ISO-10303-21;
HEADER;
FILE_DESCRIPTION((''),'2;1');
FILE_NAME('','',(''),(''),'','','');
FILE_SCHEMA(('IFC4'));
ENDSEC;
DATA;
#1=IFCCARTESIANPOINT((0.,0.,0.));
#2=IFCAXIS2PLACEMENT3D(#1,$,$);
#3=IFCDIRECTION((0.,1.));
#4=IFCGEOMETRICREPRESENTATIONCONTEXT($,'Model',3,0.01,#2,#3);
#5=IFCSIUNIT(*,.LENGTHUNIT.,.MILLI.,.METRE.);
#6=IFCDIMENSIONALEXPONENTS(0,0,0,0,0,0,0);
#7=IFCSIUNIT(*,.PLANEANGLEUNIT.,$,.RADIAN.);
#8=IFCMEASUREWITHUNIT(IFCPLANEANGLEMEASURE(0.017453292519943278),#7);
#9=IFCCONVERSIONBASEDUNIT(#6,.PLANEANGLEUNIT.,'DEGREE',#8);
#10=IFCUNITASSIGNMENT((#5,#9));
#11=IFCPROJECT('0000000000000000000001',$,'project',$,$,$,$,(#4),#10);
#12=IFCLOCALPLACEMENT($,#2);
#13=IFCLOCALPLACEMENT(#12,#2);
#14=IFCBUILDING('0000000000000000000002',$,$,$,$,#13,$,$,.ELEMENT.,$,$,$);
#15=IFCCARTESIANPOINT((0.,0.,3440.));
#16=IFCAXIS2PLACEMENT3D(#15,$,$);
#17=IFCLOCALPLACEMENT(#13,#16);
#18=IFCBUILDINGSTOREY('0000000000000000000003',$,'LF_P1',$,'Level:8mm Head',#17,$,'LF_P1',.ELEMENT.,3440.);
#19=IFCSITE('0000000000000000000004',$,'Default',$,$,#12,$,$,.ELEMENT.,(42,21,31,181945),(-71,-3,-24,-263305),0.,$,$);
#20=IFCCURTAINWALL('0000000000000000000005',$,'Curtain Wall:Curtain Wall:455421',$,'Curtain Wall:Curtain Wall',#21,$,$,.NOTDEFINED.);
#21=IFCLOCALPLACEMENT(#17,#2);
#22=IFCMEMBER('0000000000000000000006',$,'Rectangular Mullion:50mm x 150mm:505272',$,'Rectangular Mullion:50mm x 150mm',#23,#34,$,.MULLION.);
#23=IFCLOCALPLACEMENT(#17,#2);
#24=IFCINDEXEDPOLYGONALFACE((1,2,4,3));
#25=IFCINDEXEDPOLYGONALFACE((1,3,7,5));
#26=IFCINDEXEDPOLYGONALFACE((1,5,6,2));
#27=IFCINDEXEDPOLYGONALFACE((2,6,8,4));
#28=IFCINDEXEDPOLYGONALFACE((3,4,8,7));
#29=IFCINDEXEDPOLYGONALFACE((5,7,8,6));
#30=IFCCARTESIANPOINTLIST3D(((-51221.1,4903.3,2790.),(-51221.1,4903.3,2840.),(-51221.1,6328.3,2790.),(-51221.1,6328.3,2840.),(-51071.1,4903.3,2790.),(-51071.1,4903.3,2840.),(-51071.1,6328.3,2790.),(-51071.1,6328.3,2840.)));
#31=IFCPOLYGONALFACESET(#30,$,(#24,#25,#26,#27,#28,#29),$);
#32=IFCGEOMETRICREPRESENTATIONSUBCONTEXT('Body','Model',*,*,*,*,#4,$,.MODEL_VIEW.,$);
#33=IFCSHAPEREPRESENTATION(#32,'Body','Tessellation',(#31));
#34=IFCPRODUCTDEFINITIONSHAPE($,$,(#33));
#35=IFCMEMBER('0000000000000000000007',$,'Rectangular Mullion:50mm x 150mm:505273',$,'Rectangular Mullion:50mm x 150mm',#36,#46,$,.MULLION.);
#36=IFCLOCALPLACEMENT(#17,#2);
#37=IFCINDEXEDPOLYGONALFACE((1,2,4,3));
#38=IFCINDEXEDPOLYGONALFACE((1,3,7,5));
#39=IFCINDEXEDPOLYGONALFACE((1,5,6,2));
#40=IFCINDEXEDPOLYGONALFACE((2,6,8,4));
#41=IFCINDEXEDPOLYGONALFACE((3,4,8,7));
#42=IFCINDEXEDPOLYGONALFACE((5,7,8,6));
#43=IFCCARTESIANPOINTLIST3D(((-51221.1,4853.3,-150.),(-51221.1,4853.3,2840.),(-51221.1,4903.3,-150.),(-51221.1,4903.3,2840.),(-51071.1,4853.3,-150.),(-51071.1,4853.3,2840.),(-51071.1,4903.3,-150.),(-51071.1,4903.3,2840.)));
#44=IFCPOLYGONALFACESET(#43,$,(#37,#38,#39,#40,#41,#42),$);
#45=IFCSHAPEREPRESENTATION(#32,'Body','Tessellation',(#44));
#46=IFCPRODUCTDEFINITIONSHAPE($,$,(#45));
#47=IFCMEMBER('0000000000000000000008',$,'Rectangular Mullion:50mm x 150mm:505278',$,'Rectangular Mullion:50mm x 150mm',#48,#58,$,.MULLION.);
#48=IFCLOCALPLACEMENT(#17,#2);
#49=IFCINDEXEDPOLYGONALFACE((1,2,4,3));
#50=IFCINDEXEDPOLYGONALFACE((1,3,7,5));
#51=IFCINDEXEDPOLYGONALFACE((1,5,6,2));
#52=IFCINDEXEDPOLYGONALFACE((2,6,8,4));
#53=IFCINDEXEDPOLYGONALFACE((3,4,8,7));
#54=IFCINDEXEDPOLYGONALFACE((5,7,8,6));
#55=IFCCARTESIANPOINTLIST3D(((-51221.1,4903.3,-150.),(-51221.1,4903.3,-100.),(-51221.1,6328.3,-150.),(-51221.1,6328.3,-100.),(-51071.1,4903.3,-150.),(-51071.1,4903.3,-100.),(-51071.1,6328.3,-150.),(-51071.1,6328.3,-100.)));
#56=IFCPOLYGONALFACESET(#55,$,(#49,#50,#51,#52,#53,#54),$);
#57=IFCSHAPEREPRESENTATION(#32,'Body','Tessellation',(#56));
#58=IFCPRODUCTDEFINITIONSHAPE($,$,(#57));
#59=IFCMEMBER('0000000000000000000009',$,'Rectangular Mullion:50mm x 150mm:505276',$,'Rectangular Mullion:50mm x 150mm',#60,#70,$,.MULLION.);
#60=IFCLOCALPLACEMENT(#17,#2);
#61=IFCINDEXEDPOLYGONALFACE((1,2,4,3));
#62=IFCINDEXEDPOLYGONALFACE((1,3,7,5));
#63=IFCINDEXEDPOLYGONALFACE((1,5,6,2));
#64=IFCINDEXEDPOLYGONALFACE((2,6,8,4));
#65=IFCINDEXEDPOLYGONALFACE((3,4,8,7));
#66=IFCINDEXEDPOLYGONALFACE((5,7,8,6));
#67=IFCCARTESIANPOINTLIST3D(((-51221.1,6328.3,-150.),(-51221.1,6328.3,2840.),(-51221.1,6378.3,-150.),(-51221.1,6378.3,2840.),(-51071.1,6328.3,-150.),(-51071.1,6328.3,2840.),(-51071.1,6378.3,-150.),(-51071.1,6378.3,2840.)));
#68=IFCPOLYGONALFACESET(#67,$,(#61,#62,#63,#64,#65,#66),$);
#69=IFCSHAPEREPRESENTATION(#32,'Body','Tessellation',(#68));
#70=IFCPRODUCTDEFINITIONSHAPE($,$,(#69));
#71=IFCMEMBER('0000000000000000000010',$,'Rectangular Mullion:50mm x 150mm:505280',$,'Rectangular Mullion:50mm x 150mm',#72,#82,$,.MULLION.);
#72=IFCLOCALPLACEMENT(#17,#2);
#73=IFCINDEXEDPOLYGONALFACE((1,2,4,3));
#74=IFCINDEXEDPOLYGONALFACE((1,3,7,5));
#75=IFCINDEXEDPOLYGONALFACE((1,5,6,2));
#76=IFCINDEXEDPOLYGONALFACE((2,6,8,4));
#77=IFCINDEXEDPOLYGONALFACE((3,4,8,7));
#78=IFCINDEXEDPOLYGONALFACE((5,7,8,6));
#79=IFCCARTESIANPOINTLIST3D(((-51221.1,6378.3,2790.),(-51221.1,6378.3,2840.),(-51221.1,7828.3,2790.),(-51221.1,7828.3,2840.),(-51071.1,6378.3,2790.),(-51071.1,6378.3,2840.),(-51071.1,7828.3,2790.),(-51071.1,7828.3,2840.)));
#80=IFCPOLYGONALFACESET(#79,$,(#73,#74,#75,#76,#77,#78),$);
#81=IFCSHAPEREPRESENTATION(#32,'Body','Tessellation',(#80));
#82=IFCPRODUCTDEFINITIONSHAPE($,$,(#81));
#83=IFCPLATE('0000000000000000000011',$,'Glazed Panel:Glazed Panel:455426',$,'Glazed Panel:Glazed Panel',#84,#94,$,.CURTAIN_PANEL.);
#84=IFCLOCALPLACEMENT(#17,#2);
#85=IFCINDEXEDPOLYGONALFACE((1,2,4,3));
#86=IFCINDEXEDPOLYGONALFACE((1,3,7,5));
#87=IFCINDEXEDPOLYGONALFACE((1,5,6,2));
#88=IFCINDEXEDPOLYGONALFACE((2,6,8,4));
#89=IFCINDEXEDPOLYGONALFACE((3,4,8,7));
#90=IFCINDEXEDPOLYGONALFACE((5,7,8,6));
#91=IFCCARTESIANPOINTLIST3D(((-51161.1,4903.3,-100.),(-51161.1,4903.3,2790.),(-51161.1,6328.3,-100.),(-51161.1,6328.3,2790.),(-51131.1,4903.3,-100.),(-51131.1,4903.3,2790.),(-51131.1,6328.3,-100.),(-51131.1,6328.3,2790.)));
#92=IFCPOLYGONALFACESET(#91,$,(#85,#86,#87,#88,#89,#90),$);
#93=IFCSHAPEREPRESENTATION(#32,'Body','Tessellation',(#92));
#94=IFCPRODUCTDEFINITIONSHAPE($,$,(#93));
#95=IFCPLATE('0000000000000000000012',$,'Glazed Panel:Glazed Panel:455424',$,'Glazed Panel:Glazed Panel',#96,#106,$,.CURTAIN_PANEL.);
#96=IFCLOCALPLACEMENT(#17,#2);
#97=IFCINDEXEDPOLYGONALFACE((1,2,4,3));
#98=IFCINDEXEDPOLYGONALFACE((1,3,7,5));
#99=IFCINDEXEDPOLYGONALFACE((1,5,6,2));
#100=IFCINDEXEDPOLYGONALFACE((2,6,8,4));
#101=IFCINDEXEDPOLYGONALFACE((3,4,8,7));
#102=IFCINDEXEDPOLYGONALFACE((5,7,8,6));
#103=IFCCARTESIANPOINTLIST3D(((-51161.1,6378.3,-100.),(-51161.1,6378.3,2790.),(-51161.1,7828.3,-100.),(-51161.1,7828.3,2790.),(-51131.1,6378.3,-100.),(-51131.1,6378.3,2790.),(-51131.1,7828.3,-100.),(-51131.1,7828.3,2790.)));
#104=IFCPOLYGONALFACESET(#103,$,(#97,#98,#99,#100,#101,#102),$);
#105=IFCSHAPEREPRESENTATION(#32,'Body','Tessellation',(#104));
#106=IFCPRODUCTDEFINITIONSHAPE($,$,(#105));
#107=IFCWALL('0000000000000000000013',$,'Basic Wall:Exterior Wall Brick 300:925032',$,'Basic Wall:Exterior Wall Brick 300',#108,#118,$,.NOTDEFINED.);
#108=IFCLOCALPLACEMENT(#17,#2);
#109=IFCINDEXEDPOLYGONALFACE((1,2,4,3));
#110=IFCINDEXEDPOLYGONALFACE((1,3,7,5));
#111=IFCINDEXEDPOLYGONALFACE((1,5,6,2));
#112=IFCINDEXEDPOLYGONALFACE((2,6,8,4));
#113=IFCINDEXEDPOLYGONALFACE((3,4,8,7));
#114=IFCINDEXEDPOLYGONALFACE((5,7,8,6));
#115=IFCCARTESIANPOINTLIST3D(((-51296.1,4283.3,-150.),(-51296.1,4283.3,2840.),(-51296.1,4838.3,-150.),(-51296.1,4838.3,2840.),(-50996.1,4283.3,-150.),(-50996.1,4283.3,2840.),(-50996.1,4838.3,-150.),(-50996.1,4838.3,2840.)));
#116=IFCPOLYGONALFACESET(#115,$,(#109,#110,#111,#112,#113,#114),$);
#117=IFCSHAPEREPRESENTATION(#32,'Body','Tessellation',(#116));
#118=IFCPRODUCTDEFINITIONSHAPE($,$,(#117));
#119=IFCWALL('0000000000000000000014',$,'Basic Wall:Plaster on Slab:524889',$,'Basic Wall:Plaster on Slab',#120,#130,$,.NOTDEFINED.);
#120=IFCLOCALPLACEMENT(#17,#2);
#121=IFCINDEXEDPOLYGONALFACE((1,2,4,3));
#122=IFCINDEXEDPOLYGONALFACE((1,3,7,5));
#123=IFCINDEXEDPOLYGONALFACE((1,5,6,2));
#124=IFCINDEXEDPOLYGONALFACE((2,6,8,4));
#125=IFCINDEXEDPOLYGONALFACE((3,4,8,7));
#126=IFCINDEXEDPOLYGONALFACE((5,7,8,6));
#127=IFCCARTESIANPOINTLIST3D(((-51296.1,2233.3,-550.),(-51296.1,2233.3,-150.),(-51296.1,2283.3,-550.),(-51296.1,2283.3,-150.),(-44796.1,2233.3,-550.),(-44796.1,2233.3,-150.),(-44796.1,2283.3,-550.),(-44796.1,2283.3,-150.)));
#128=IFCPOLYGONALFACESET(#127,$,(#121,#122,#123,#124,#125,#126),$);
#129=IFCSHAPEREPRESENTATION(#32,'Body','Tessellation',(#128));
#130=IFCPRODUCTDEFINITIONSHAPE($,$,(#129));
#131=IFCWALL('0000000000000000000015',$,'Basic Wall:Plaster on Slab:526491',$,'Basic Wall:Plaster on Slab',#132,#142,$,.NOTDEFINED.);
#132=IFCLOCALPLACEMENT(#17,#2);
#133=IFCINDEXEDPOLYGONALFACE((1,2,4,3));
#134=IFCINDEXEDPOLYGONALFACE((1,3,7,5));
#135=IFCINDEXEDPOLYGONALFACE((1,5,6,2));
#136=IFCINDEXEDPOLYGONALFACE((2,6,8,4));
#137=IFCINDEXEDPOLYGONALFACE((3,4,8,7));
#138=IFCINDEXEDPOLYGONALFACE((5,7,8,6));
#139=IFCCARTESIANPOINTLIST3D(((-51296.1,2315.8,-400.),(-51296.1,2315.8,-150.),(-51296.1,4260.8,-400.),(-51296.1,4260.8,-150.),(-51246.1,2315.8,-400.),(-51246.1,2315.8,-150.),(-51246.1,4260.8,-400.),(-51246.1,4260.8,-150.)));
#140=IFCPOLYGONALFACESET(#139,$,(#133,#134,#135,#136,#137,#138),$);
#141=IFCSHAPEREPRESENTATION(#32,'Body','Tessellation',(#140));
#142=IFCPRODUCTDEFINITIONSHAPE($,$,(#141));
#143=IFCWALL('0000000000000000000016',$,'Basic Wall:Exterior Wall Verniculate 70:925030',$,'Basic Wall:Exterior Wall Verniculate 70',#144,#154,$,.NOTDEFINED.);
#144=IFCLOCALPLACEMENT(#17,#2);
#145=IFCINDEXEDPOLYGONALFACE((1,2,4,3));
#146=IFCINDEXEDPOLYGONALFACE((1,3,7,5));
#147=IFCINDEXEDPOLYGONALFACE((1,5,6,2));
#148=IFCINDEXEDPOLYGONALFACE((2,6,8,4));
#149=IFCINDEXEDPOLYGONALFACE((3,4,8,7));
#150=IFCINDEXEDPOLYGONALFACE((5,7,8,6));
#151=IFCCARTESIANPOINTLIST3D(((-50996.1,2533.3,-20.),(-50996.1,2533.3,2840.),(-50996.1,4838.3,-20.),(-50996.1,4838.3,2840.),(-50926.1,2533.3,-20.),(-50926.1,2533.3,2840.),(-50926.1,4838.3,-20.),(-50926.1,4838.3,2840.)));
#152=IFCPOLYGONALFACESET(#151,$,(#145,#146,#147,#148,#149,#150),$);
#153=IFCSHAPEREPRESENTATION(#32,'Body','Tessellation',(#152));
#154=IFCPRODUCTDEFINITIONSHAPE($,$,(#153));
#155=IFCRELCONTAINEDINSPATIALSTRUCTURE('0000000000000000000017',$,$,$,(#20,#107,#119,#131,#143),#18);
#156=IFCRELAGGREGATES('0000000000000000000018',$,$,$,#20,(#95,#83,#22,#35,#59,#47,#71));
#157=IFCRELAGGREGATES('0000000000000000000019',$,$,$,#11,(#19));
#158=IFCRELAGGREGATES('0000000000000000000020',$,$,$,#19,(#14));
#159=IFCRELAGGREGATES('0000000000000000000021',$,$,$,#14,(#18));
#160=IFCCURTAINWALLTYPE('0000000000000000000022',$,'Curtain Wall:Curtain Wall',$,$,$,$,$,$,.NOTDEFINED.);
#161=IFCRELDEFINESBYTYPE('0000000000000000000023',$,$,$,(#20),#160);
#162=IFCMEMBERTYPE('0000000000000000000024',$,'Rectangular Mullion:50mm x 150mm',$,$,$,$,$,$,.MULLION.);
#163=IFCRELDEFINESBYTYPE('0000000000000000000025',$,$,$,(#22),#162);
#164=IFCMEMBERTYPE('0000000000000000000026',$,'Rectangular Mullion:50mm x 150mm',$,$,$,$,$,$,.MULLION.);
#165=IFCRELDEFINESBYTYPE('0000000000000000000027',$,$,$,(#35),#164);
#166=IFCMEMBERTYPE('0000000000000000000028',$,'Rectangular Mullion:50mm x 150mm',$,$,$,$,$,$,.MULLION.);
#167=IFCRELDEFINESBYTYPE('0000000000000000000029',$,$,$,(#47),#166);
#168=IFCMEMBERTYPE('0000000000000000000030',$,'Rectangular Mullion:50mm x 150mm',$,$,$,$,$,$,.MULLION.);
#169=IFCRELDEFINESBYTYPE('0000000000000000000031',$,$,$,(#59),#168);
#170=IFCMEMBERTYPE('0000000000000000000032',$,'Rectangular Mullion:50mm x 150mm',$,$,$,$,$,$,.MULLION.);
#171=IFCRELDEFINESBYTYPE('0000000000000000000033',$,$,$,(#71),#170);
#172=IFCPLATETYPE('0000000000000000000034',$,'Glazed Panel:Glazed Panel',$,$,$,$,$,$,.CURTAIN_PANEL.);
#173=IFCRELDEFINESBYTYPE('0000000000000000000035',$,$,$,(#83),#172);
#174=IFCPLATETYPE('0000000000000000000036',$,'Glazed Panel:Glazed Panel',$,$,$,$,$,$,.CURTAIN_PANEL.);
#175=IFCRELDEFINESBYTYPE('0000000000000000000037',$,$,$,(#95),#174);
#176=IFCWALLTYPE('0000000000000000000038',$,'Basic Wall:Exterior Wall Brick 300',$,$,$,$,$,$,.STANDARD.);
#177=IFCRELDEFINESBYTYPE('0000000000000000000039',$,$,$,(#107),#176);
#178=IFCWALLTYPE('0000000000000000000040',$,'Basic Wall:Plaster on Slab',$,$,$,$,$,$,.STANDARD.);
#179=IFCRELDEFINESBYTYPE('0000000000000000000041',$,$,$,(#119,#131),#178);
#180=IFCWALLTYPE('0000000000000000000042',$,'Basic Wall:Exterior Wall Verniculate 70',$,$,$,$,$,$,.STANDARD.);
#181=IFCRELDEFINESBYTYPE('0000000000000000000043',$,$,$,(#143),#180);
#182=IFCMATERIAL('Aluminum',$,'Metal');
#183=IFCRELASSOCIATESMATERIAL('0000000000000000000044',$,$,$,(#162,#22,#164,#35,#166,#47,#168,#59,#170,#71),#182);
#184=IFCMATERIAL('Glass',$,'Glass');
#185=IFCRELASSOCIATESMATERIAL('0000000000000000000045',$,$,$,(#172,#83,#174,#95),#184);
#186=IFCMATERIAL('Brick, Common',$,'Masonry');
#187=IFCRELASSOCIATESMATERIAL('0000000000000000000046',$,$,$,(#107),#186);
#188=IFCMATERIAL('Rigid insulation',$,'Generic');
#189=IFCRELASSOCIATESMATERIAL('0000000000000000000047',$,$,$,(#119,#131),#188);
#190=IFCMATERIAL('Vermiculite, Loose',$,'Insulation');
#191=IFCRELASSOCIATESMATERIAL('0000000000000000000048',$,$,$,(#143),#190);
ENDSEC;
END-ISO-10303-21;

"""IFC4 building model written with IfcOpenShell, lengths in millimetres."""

from ifc_helpers import new_model, entity, si_unit, converted_unit, direction, frame, origin, place, context, subcontext, project, spatial, indexed_curve, outline, extrude, source, transform, mapped, material, type_object, type_shapes, element, aggregate, save


model = new_model("IFC4")

# Units and contexts
model_context = context("Model", 3, precision=0.01, world=origin(), true_north=direction((0.0, 1.0)))
body_context = subcontext(model_context, "Body", "Model", "MODEL_VIEW")
ifc_project = project(units=[si_unit("LENGTHUNIT", "METRE", prefix="MILLI"), converted_unit("PLANEANGLEUNIT", "DEGREE", entity("IfcPlaneAngleMeasure", 0.017453292519943278), si_unit("PLANEANGLEUNIT", "RADIAN"), dimensions=[0, 0, 0, 0, 0, 0, 0])], contexts=[model_context])

# Site, building, storey
site_placement = place(None, origin())
site = spatial("IfcSite", under=ifc_project, at=site_placement, Name="Default", CompositionType="ELEMENT", RefLatitude=(42, 21, 31, 181945), RefLongitude=(-71, -3, -24, -263305), RefElevation=0.0)
building_placement = place(site_placement, origin())
building = spatial("IfcBuilding", under=site, at=building_placement, CompositionType="ELEMENT")
storey_placement = place(building_placement, frame((0.0, 0.0, 3440.0)))
storey = spatial("IfcBuildingStorey", under=building, at=storey_placement, Name="LF_P1", ObjectType="Level:8mm Head", LongName="LF_P1", CompositionType="ELEMENT", Elevation=3440.0)

# Curtain wall, members, plates
curtain_wall_type = type_object("IfcCurtainWallType", Name="Curtain Wall:Curtain Wall", PredefinedType="NOTDEFINED")
curtain_wall_placement = place(storey_placement, frame((0.0, 0.0, -3440.0)))
curtain_wall = element("IfcCurtainWall", 1, at=curtain_wall_placement, inside=storey, type_object=curtain_wall_type, Name="Curtain Wall:Curtain Wall:455421", ObjectType="Curtain Wall:Curtain Wall", PredefinedType="NOTDEFINED")
ifc_material_1 = material(Name="Aluminum", Category="Metal")
member_type_1 = type_object("IfcMemberType", Name="Rectangular Mullion:50mm x 150mm", PredefinedType="MULLION", material=ifc_material_1)
shared_shape_1 = source(origin(), body_context, "Body", "SweptSolid", [
    extrude(outline(indexed_curve([(-25.0, -75.0), (25.0, -75.0), (25.0, 75.0), (-25.0, 75.0), (-25.0, -75.0)], self_intersect=False)), frame((-25.0, 0.0, -1425.0), z_axis=(0.0, 0.0, 1.0), x_axis=(-1.0, 0.0, 0.0)), (0.0, 0.0, 1.0), 1425.0),
])
type_shapes(member_type_1, [shared_shape_1])
member_1_placement = place(curtain_wall_placement, frame((-51146.1, 4903.3, 6280.0), z_axis=(0.0, -1.0, 0.0), x_axis=(0.0, 0.0, 1.0)))
member_1 = element("IfcMember", 2, at=member_1_placement, type_object=member_type_1, material=ifc_material_1, Name="Rectangular Mullion:50mm x 150mm:505272", ObjectType="Rectangular Mullion:50mm x 150mm", PredefinedType="MULLION", context=body_context, shape_type="MappedRepresentation", body=[
    mapped(shared_shape_1, transform((0.0, 0.0, 0.0), scale=1.0)),
])
member_type_2 = type_object("IfcMemberType", Name="Rectangular Mullion:50mm x 150mm", PredefinedType="MULLION", material=ifc_material_1)
shared_shape_2 = source(origin(), body_context, "Body", "SweptSolid", [
    extrude(outline(indexed_curve([(-25.0, -75.0), (25.0, -75.0), (25.0, 75.0), (-25.0, 75.0), (-25.0, -75.0)], self_intersect=False)), frame((-25.0, 0.0, -2990.0), z_axis=(0.0, 0.0, 1.0), x_axis=(-1.0, 0.0, 0.0)), (0.0, 0.0, 1.0), 2990.0),
])
type_shapes(member_type_2, [shared_shape_2])
member_2_placement = place(curtain_wall_placement, frame((-51146.1, 4853.3, 3290.0), z_axis=(0.0, 0.0, -1.0), x_axis=(0.0, -1.0, 0.0)))
member_2 = element("IfcMember", 3, at=member_2_placement, type_object=member_type_2, material=ifc_material_1, Name="Rectangular Mullion:50mm x 150mm:505273", ObjectType="Rectangular Mullion:50mm x 150mm", PredefinedType="MULLION", context=body_context, shape_type="MappedRepresentation", body=[
    mapped(shared_shape_2, transform((0.0, 0.0, 0.0), scale=1.0)),
])
member_type_3 = type_object("IfcMemberType", Name="Rectangular Mullion:50mm x 150mm", PredefinedType="MULLION", material=ifc_material_1)
shared_shape_3 = source(origin(), body_context, "Body", "SweptSolid", [
    extrude(outline(indexed_curve([(-25.0, -75.0), (25.0, -75.0), (25.0, 75.0), (-25.0, 75.0), (-25.0, -75.0)], self_intersect=False)), frame((-25.0, 0.0, -1425.0), z_axis=(0.0, 0.0, 1.0), x_axis=(-1.0, 0.0, 0.0)), (0.0, 0.0, 1.0), 1425.0),
])
type_shapes(member_type_3, [shared_shape_3])
member_3_placement = place(curtain_wall_placement, frame((-51146.1, 6328.3, 3290.0), z_axis=(0.0, 1.0, 0.0), x_axis=(0.0, 0.0, -1.0)))
member_3 = element("IfcMember", 4, at=member_3_placement, type_object=member_type_3, material=ifc_material_1, Name="Rectangular Mullion:50mm x 150mm:505278", ObjectType="Rectangular Mullion:50mm x 150mm", PredefinedType="MULLION", context=body_context, shape_type="MappedRepresentation", body=[
    mapped(shared_shape_3, transform((0.0, 0.0, 0.0), scale=1.0)),
])
member_type_4 = type_object("IfcMemberType", Name="Rectangular Mullion:50mm x 150mm", PredefinedType="MULLION", material=ifc_material_1)
shared_shape_4 = source(origin(), body_context, "Body", "SweptSolid", [
    extrude(outline(indexed_curve([(-25.0, -75.0), (25.0, -75.0), (25.0, 75.0), (-25.0, 75.0), (-25.0, -75.0)], self_intersect=False)), frame((0.0, 0.0, -2990.0), z_axis=(0.0, 0.0, 1.0), x_axis=(-1.0, 0.0, 0.0)), (0.0, 0.0, 1.0), 2990.0),
])
type_shapes(member_type_4, [shared_shape_4])
member_4_placement = place(curtain_wall_placement, frame((-51146.1, 6353.3, 3290.0), z_axis=(0.0, 0.0, -1.0), x_axis=(0.0, -1.0, 0.0)))
member_4 = element("IfcMember", 5, at=member_4_placement, type_object=member_type_4, material=ifc_material_1, Name="Rectangular Mullion:50mm x 150mm:505276", ObjectType="Rectangular Mullion:50mm x 150mm", PredefinedType="MULLION", context=body_context, shape_type="MappedRepresentation", body=[
    mapped(shared_shape_4, transform((0.0, 0.0, 0.0), scale=1.0)),
])
member_type_5 = type_object("IfcMemberType", Name="Rectangular Mullion:50mm x 150mm", PredefinedType="MULLION", material=ifc_material_1)
shared_shape_5 = source(origin(), body_context, "Body", "SweptSolid", [
    extrude(outline(indexed_curve([(-25.0, -75.0), (25.0, -75.0), (25.0, 75.0), (-25.0, 75.0), (-25.0, -75.0)], self_intersect=False)), frame((-25.0, 0.0, -1450.0), z_axis=(0.0, 0.0, 1.0), x_axis=(-1.0, 0.0, 0.0)), (0.0, 0.0, 1.0), 1450.0),
])
type_shapes(member_type_5, [shared_shape_5])
member_5_placement = place(curtain_wall_placement, frame((-51146.1, 6378.3, 6280.0), z_axis=(0.0, -1.0, 0.0), x_axis=(0.0, 0.0, 1.0)))
member_5 = element("IfcMember", 6, at=member_5_placement, type_object=member_type_5, material=ifc_material_1, Name="Rectangular Mullion:50mm x 150mm:505280", ObjectType="Rectangular Mullion:50mm x 150mm", PredefinedType="MULLION", context=body_context, shape_type="MappedRepresentation", body=[
    mapped(shared_shape_5, transform((0.0, 0.0, 0.0), scale=1.0)),
])
ifc_material_2 = material(Name="Glass", Category="Glass")
plate_type_1 = type_object("IfcPlateType", Name="Glazed Panel:Glazed Panel", PredefinedType="CURTAIN_PANEL", material=ifc_material_2)
shared_shape_6 = source(origin(), body_context, "Body", "SweptSolid", [
    extrude(outline(indexed_curve([(-15.0, -712.5), (15.0, -712.5), (15.0, 712.5), (-15.0, 712.5), (-15.0, -712.5)], self_intersect=False)), frame((0.0, 0.0, 0.0), z_axis=(0.0, 0.0, 1.0), x_axis=(0.0, 1.0, 0.0)), (0.0, 0.0, 1.0), 2890.0),
])
type_shapes(plate_type_1, [shared_shape_6])
plate_1_placement = place(curtain_wall_placement, frame((-51146.1, 5615.8, 3340.0), z_axis=(0.0, 0.0, 1.0), x_axis=(0.0, -1.0, 0.0)))
plate_1 = element("IfcPlate", 7, at=plate_1_placement, type_object=plate_type_1, material=ifc_material_2, Name="Glazed Panel:Glazed Panel:455426", ObjectType="Glazed Panel:Glazed Panel", PredefinedType="CURTAIN_PANEL", context=body_context, shape_type="MappedRepresentation", body=[
    mapped(shared_shape_6, transform((0.0, 0.0, 0.0), scale=1.0)),
])
plate_type_2 = type_object("IfcPlateType", Name="Glazed Panel:Glazed Panel", PredefinedType="CURTAIN_PANEL", material=ifc_material_2)
shared_shape_7 = source(origin(), body_context, "Body", "SweptSolid", [
    extrude(outline(indexed_curve([(-15.0, -725.0), (15.0, -725.0), (15.0, 725.0), (-15.0, 725.0), (-15.0, -725.0)], self_intersect=False)), frame((0.0, 0.0, 0.0), z_axis=(0.0, 0.0, 1.0), x_axis=(0.0, 1.0, 0.0)), (0.0, 0.0, 1.0), 2890.0),
])
type_shapes(plate_type_2, [shared_shape_7])
plate_2_placement = place(curtain_wall_placement, frame((-51146.1, 7103.3, 3340.0), z_axis=(0.0, 0.0, 1.0), x_axis=(0.0, -1.0, 0.0)))
plate_2 = element("IfcPlate", 8, at=plate_2_placement, type_object=plate_type_2, material=ifc_material_2, Name="Glazed Panel:Glazed Panel:455424", ObjectType="Glazed Panel:Glazed Panel", PredefinedType="CURTAIN_PANEL", context=body_context, shape_type="MappedRepresentation", body=[
    mapped(shared_shape_7, transform((0.0, 0.0, 0.0), scale=1.0)),
])
aggregate(curtain_wall, [plate_2, plate_1, member_1, member_2, member_4, member_3, member_5])

# Walls
ifc_material_3 = material(Name="Brick, Common", Category="Masonry")
wall_type_1 = type_object("IfcWallType", Name="Basic Wall:Exterior Wall Brick 300", PredefinedType="STANDARD")
wall_1_placement = place(storey_placement, frame((-51146.1, 4283.3, -150.0), z_axis=(0.0, 0.0, 1.0), x_axis=(0.0, 1.0, 0.0)))
element("IfcWall", 9, at=wall_1_placement, inside=storey, type_object=wall_type_1, material=ifc_material_3, Name="Basic Wall:Exterior Wall Brick 300:925032", ObjectType="Basic Wall:Exterior Wall Brick 300", PredefinedType="NOTDEFINED", context=body_context, shape_type="SweptSolid", body=[
    extrude(outline(indexed_curve([(555.0, 150.0), (0.0, 150.0), (0.0, -150.0), (555.0, -150.0), (555.0, 150.0)], self_intersect=False)), origin(), (0.0, 0.0, 1.0), 2990.0),
])
ifc_material_4 = material(Name="Rigid insulation", Category="Generic")
wall_type_2 = type_object("IfcWallType", Name="Basic Wall:Plaster on Slab", PredefinedType="STANDARD")
wall_2_placement = place(storey_placement, frame((-51296.1, 2258.3, -550.0)))
element("IfcWall", 10, at=wall_2_placement, inside=storey, type_object=wall_type_2, material=ifc_material_4, Name="Basic Wall:Plaster on Slab:524889", ObjectType="Basic Wall:Plaster on Slab", PredefinedType="NOTDEFINED", context=body_context, shape_type="SweptSolid", body=[
    extrude(outline(indexed_curve([(6500.0, 25.0), (0.0, 25.0), (0.0, -25.0), (6500.0, -25.0), (6500.0, 25.0)], self_intersect=False)), origin(), (0.0, 0.0, 1.0), 400.0),
])
wall_3_placement = place(storey_placement, frame((-51271.1, 4260.8, -400.0), z_axis=(0.0, 0.0, 1.0), x_axis=(0.0, -1.0, 0.0)))
element("IfcWall", 11, at=wall_3_placement, inside=storey, type_object=wall_type_2, material=ifc_material_4, Name="Basic Wall:Plaster on Slab:526491", ObjectType="Basic Wall:Plaster on Slab", PredefinedType="NOTDEFINED", context=body_context, shape_type="SweptSolid", body=[
    extrude(outline(indexed_curve([(1945.0, 25.0), (0.0, 25.0), (0.0, -25.0), (1945.0, -25.0), (1945.0, 25.0)], self_intersect=False)), origin(), (0.0, 0.0, 1.0), 250.0),
])
ifc_material_5 = material(Name="Vermiculite, Loose", Category="Insulation")
wall_type_3 = type_object("IfcWallType", Name="Basic Wall:Exterior Wall Verniculate 70", PredefinedType="STANDARD")
wall_4_placement = place(storey_placement, frame((-50961.1, 2533.3, -20.0), z_axis=(0.0, 0.0, 1.0), x_axis=(0.0, 1.0, 0.0)))
element("IfcWall", 12, at=wall_4_placement, inside=storey, type_object=wall_type_3, material=ifc_material_5, Name="Basic Wall:Exterior Wall Verniculate 70:925030", ObjectType="Basic Wall:Exterior Wall Verniculate 70", PredefinedType="NOTDEFINED", context=body_context, shape_type="SweptSolid", body=[
    extrude(outline(indexed_curve([(2305.0, 35.0), (0.0, 35.0), (0.0, -35.0), (2305.0, -35.0), (2305.0, 35.0)], self_intersect=False)), origin(), (0.0, 0.0, 1.0), 2860.0),
])

save(model, "model.ifc")
